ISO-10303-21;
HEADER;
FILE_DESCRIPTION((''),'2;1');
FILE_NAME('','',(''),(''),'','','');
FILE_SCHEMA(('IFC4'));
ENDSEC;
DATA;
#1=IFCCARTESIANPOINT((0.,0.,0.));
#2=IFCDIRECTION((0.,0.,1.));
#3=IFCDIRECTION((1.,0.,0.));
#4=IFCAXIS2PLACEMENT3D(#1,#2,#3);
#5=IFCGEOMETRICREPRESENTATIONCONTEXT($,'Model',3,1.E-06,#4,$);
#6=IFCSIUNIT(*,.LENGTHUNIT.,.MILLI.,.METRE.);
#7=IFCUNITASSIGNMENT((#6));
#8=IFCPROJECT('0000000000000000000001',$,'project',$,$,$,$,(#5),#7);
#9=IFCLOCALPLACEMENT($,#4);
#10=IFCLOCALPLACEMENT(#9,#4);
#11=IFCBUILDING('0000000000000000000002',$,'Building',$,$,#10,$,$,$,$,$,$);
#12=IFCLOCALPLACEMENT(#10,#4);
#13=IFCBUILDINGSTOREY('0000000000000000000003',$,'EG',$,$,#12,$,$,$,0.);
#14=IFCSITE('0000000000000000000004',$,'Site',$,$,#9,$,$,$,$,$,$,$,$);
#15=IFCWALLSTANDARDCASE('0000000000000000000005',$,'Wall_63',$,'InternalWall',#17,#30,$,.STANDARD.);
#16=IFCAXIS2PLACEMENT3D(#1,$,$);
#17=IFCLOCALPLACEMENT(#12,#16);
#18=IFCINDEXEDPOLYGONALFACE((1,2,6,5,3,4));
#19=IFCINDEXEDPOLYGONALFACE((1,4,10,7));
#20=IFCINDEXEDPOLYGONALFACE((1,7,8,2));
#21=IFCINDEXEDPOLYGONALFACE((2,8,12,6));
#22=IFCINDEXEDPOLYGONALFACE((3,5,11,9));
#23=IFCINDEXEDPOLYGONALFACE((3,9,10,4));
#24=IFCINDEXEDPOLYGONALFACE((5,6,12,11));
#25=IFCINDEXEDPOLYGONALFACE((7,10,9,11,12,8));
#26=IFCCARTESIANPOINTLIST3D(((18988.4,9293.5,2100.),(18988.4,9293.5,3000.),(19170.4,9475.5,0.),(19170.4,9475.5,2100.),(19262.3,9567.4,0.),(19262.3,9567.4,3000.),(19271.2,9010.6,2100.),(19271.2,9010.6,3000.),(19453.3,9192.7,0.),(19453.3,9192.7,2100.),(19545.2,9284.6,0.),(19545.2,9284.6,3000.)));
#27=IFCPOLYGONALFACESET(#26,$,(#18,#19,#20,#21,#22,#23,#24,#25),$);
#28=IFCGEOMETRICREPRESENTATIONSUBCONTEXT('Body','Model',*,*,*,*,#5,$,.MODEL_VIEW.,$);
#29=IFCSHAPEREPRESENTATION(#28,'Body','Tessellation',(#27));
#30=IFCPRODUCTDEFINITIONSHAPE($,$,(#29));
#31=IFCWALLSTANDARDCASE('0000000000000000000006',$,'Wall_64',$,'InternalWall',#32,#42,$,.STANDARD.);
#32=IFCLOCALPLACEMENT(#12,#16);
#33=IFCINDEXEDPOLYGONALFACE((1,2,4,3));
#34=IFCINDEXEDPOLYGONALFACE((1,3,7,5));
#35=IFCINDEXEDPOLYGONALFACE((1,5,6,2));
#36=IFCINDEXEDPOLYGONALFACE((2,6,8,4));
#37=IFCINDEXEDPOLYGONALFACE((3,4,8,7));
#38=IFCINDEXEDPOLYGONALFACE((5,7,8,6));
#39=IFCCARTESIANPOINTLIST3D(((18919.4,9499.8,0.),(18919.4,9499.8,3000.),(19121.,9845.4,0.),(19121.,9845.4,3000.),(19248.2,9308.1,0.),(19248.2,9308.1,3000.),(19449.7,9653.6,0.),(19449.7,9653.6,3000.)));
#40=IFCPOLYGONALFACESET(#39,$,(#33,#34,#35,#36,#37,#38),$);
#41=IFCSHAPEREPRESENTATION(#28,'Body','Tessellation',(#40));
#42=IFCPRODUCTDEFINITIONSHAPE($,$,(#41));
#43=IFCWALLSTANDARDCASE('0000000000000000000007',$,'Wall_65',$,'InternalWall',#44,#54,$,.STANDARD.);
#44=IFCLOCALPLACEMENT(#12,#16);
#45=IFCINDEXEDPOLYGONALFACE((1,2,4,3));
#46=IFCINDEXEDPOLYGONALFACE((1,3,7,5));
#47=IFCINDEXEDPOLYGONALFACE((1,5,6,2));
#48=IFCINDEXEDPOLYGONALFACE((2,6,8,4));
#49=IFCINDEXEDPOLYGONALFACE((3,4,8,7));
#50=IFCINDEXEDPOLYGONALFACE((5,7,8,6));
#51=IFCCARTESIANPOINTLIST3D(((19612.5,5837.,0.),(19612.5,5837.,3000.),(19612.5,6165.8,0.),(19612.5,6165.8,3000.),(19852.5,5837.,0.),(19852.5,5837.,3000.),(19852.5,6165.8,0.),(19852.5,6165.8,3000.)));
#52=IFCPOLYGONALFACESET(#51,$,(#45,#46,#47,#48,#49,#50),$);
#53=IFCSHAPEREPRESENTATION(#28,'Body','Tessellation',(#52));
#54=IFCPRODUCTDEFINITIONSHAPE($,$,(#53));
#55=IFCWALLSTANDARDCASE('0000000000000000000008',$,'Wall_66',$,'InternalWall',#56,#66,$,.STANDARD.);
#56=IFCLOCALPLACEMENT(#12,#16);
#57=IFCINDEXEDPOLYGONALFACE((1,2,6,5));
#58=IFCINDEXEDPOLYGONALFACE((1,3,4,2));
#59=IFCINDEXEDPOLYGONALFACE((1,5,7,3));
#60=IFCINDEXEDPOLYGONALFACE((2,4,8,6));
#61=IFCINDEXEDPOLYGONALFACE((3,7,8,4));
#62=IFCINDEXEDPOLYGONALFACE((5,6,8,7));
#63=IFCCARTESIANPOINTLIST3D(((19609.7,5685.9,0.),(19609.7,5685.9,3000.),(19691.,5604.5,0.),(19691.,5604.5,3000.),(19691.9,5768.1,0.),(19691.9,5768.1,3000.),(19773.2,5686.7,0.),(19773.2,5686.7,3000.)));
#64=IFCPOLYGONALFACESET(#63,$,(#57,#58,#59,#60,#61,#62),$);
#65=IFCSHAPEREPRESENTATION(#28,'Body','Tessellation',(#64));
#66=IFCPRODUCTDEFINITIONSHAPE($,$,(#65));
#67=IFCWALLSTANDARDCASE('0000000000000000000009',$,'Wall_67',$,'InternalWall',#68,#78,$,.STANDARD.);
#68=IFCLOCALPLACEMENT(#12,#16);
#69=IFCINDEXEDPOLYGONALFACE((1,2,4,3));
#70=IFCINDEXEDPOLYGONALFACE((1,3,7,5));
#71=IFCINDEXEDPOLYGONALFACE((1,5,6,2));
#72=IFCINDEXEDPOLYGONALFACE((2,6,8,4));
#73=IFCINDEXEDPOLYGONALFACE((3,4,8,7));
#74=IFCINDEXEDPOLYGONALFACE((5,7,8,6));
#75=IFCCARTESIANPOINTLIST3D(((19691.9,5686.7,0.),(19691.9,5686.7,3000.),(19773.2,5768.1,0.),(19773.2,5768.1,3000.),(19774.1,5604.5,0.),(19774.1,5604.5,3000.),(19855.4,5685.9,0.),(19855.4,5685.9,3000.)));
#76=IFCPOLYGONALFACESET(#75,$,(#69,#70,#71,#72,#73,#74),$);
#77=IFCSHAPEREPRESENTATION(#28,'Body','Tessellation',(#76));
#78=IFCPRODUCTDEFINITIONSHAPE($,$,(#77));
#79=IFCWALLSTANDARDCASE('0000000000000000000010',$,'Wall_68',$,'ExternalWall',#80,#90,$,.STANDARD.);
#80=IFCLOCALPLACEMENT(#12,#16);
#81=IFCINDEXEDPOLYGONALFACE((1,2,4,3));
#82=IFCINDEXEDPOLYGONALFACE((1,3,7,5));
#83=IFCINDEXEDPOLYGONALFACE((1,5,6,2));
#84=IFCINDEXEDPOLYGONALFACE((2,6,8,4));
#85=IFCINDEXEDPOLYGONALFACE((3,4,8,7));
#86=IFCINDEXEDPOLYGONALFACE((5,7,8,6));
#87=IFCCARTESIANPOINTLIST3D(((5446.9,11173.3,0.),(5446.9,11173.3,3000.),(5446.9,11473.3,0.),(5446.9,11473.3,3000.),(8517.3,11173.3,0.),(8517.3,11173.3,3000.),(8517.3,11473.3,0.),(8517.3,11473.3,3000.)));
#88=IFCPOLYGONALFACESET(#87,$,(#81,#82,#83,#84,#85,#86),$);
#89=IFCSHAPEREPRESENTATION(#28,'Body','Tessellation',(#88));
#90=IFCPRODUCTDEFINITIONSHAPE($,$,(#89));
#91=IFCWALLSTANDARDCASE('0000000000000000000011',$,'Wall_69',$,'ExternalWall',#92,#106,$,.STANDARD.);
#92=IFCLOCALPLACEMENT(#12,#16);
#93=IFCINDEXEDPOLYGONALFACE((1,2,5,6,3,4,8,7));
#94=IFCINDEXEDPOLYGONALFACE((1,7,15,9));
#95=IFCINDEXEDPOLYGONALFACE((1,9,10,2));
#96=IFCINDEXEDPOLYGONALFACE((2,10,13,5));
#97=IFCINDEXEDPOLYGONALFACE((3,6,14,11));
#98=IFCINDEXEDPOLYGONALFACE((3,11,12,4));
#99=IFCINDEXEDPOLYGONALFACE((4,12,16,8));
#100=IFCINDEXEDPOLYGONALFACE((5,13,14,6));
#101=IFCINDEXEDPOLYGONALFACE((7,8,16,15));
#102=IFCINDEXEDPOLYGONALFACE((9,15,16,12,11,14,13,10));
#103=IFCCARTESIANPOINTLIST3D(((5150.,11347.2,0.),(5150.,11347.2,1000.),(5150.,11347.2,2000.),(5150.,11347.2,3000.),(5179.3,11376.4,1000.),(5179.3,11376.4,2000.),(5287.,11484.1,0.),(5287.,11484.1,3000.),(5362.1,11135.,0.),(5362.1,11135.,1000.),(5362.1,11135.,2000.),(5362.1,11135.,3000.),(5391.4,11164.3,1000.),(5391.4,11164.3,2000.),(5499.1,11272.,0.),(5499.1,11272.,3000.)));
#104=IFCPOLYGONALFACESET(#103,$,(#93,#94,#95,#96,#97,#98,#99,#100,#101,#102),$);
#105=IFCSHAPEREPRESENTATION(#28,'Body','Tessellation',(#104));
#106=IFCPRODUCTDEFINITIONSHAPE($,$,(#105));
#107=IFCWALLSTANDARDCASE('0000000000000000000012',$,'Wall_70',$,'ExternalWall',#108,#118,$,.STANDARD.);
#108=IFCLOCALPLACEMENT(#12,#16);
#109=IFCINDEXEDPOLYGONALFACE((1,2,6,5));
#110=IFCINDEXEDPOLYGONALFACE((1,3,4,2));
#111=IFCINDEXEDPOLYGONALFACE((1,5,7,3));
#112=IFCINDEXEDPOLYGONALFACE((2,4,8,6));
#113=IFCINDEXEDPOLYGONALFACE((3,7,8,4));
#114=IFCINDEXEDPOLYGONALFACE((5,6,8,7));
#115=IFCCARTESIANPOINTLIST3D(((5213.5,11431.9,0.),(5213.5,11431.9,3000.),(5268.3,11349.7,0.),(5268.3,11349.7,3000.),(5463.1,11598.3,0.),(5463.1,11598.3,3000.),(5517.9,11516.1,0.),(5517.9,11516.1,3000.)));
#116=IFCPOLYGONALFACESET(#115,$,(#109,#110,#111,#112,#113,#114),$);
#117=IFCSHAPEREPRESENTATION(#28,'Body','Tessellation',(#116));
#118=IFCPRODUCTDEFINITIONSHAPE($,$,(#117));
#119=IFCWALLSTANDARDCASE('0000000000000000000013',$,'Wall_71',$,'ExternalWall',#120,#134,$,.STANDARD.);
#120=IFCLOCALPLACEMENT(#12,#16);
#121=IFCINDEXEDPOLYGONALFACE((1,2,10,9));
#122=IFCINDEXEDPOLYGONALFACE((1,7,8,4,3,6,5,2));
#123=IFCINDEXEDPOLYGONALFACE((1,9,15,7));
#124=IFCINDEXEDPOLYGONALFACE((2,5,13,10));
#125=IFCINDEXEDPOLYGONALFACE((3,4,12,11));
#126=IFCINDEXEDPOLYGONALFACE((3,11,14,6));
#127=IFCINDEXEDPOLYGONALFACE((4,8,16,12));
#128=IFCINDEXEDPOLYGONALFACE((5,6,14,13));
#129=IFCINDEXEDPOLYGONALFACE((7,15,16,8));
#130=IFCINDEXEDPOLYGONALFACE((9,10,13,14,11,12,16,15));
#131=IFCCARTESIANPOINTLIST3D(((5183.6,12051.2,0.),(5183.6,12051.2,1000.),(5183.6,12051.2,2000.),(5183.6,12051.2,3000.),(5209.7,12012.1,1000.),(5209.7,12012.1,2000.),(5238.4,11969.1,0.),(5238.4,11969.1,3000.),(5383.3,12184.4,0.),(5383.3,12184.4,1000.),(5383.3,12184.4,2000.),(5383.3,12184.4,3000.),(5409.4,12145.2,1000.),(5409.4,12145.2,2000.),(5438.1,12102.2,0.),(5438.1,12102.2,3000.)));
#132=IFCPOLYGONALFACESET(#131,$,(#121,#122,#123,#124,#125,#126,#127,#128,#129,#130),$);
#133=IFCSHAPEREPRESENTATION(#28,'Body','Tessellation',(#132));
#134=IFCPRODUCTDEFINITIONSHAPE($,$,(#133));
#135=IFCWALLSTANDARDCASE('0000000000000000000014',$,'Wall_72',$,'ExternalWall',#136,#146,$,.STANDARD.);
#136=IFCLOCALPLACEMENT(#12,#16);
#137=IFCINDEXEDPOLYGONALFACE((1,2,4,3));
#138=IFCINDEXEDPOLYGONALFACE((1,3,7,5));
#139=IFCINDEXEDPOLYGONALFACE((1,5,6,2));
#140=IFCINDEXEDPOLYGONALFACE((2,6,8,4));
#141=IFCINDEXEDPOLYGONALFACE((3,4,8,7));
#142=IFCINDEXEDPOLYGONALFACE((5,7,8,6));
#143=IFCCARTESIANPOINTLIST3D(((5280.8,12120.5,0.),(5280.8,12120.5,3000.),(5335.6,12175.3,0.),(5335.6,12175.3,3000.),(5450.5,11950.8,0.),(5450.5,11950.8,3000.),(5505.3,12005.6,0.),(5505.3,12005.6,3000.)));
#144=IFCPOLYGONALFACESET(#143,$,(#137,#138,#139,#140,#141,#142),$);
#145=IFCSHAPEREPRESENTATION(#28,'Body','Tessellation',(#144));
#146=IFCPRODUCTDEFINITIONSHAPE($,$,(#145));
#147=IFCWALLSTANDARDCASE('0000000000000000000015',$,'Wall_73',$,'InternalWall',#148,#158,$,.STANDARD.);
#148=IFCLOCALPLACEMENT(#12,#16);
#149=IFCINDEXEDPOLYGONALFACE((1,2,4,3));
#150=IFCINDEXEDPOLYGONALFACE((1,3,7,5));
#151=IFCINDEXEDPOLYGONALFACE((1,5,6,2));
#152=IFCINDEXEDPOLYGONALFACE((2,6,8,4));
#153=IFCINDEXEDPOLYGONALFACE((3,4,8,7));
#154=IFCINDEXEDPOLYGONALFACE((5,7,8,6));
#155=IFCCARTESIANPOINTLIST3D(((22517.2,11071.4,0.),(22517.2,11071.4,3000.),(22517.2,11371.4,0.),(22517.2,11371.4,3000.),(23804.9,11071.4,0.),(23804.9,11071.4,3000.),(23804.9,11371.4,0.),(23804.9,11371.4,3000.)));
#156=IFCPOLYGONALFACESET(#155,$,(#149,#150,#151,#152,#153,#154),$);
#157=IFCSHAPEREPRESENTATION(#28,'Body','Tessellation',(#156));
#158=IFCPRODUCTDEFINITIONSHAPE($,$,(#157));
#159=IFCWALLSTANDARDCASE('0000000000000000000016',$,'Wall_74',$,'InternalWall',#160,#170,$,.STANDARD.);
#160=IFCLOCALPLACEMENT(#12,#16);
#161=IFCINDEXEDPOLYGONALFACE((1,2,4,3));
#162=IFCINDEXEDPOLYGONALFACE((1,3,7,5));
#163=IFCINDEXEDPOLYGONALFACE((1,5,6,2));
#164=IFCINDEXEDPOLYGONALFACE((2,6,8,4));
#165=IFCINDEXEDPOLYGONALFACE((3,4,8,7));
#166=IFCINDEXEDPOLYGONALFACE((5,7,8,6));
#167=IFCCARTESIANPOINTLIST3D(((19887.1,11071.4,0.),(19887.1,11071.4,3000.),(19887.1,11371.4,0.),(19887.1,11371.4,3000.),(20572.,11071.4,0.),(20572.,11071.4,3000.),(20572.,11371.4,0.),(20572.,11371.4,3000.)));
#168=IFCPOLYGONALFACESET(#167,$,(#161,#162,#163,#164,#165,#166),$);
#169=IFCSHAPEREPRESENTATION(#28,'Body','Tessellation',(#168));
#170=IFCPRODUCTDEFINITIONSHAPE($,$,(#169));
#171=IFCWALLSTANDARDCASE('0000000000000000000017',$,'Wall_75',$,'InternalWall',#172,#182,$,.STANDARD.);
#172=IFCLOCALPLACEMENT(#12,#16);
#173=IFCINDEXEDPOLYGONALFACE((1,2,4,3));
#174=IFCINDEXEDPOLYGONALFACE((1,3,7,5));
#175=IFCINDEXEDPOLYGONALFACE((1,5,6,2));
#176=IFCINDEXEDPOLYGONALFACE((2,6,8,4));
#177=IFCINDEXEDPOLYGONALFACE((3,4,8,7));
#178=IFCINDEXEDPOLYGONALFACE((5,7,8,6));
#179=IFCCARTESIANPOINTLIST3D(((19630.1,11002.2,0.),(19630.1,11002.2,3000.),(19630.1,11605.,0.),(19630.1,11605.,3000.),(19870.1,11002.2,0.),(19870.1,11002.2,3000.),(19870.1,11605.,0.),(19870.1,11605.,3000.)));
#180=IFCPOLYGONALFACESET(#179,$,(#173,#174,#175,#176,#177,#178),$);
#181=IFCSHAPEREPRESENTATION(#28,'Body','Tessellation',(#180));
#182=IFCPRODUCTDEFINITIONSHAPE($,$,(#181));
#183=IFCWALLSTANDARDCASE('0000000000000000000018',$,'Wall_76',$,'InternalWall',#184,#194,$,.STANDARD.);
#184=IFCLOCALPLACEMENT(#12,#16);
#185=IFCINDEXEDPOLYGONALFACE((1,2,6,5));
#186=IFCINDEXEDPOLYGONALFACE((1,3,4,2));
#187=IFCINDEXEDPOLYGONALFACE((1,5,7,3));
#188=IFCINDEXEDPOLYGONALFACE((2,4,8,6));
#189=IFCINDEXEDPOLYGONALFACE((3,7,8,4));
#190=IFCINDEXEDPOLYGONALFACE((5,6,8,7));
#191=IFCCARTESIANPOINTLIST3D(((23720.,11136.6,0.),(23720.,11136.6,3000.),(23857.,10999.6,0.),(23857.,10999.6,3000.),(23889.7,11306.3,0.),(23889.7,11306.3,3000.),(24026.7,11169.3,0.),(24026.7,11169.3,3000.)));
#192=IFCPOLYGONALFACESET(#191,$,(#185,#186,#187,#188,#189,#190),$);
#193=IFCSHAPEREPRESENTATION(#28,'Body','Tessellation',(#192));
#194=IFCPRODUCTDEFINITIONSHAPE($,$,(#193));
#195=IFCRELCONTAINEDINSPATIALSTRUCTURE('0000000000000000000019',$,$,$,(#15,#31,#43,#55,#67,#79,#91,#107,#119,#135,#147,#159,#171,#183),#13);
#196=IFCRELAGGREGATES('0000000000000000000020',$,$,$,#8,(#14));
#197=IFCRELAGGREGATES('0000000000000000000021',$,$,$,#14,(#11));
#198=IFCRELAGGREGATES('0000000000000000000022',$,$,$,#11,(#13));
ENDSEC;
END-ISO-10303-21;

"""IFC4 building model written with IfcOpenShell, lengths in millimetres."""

from ifc_helpers import new_model, si_unit, frame, origin_with_axes, place, context, subcontext, project, spatial, rectangle, extrude, element, save


model = new_model("IFC4")

# Units and contexts
model_context = context("Model", 3, precision=1e-06, world=origin_with_axes())
body_context = subcontext(model_context, "Body", "Model", "MODEL_VIEW")
ifc_project = project(units=[si_unit("LENGTHUNIT", "METRE", prefix="MILLI")], contexts=[model_context])

# Site, building, storey
site_placement = place(None, origin_with_axes())
site = spatial("IfcSite", under=ifc_project, at=site_placement, Name="Site")
building_placement = place(site_placement, origin_with_axes())
building = spatial("IfcBuilding", under=site, at=building_placement, Name="Building")
storey_placement = place(building_placement, origin_with_axes())
storey = spatial("IfcBuildingStorey", under=building, at=storey_placement, Name="EG", Elevation=0.0)

# Wall, opening
wall_1_placement = place(storey_placement, origin_with_axes())
wall_1 = element("IfcWallStandardCase", 1, at=wall_1_placement, inside=storey, Name="Wall_63", ObjectType="InternalWall", PredefinedType="STANDARD", context=body_context, shape_type="SweptSolid", body=[
    extrude(rectangle(XDim=387.5, YDim=400.0), frame((19266.8, 9289.0, 0.0), z_axis=(0.0, 0.0, 1.0), x_axis=(-0.707107, -0.707107, 0.0)), (0.0, 0.0, 1.0), 3000.0),
])
opening_1_placement = place(wall_1_placement, origin_with_axes())
element("IfcOpeningElement", 2, at=opening_1_placement, inside=storey, cuts=wall_1, context=body_context, shape_type="SweptSolid", body=[
    extrude(rectangle(XDim=1034.0, YDim=400.0), frame((18946.3, 8968.5, 0.0), z_axis=(0.0, 0.0, 1.0), x_axis=(-0.707107, -0.707107, 0.0)), (0.0, 0.0, 1.0), 2100.0),
])

# Walls
wall_2_placement = place(storey_placement, origin_with_axes())
element("IfcWallStandardCase", 3, at=wall_2_placement, inside=storey, Name="Wall_64", ObjectType="InternalWall", PredefinedType="STANDARD", context=body_context, shape_type="SweptSolid", body=[
    extrude(rectangle(XDim=380.6, YDim=400.0), frame((19184.6, 9576.7, 0.0), z_axis=(0.0, 0.0, 1.0), x_axis=(-0.863779, 0.503871, 0.0)), (0.0, 0.0, 1.0), 3000.0),
])
wall_3_placement = place(storey_placement, origin_with_axes())
element("IfcWallStandardCase", 4, at=wall_3_placement, inside=storey, Name="Wall_65", ObjectType="InternalWall", PredefinedType="STANDARD", context=body_context, shape_type="SweptSolid", body=[
    extrude(rectangle(XDim=328.8, YDim=240.0), frame((19732.5, 6001.4, 0.0), z_axis=(0.0, 0.0, 1.0), x_axis=(0.0, -1.0, 0.0)), (0.0, 0.0, 1.0), 3000.0),
])
wall_4_placement = place(storey_placement, origin_with_axes())
element("IfcWallStandardCase", 5, at=wall_4_placement, inside=storey, Name="Wall_66", ObjectType="InternalWall", PredefinedType="STANDARD", context=body_context, shape_type="SweptSolid", body=[
    extrude(rectangle(XDim=116.2, YDim=115.0), frame((19691.4, 5686.3, 0.0), z_axis=(0.0, 0.0, 1.0), x_axis=(-0.707107, -0.707107, 0.0)), (0.0, 0.0, 1.0), 3000.0),
])
wall_5_placement = place(storey_placement, origin_with_axes())
element("IfcWallStandardCase", 6, at=wall_5_placement, inside=storey, Name="Wall_67", ObjectType="InternalWall", PredefinedType="STANDARD", context=body_context, shape_type="SweptSolid", body=[
    extrude(rectangle(XDim=116.2, YDim=115.0), frame((19773.6, 5686.3, 0.0), z_axis=(0.0, 0.0, 1.0), x_axis=(0.707107, -0.707107, 0.0)), (0.0, 0.0, 1.0), 3000.0),
])
wall_6_placement = place(storey_placement, origin_with_axes())
element("IfcWallStandardCase", 7, at=wall_6_placement, inside=storey, Name="Wall_68", ObjectType="ExternalWall", PredefinedType="STANDARD", context=body_context, shape_type="SweptSolid", body=[
    extrude(rectangle(XDim=3070.4, YDim=300.0), frame((6982.1, 11323.3, 0.0), z_axis=(0.0, 0.0, 1.0), x_axis=(1.0, 0.0, 0.0)), (0.0, 0.0, 1.0), 3000.0),
])

# Wall, opening
wall_7_placement = place(storey_placement, origin_with_axes())
wall_7 = element("IfcWallStandardCase", 8, at=wall_7_placement, inside=storey, Name="Wall_69", ObjectType="ExternalWall", PredefinedType="STANDARD", context=body_context, shape_type="SweptSolid", body=[
    extrude(rectangle(XDim=193.7, YDim=300.0), frame((5324.6, 11309.6, 0.0), z_axis=(0.0, 0.0, 1.0), x_axis=(-0.707107, -0.707107, 0.0)), (0.0, 0.0, 1.0), 3000.0),
])
opening_2_placement = place(wall_7_placement, origin_with_axes())
element("IfcOpeningElement", 9, at=opening_2_placement, inside=storey, cuts=wall_7, context=body_context, shape_type="SweptSolid", body=[
    extrude(rectangle(XDim=627.8, YDim=300.0), frame((5063.4, 11048.4, 1000.0), z_axis=(0.0, 0.0, 1.0), x_axis=(-0.707107, -0.707107, 0.0)), (0.0, 0.0, 1.0), 1000.0),
])

# Wall
wall_8_placement = place(storey_placement, origin_with_axes())
element("IfcWallStandardCase", 10, at=wall_8_placement, inside=storey, Name="Wall_70", ObjectType="ExternalWall", PredefinedType="STANDARD", context=body_context, shape_type="SweptSolid", body=[
    extrude(rectangle(XDim=98.8, YDim=300.0), frame((5365.7, 11474.0, 0.0), z_axis=(0.0, 0.0, 1.0), x_axis=(0.5547, -0.83205, 0.0)), (0.0, 0.0, 1.0), 3000.0),
])

# Wall, opening
wall_9_placement = place(storey_placement, origin_with_axes())
wall_9 = element("IfcWallStandardCase", 11, at=wall_9_placement, inside=storey, Name="Wall_71", ObjectType="ExternalWall", PredefinedType="STANDARD", context=body_context, shape_type="SweptSolid", body=[
    extrude(rectangle(XDim=98.8, YDim=240.0), frame((5310.9, 12076.7, 0.0), z_axis=(0.0, 0.0, 1.0), x_axis=(-0.5547, 0.83205, 0.0)), (0.0, 0.0, 1.0), 3000.0),
])
opening_3_placement = place(wall_9_placement, origin_with_axes())
element("IfcOpeningElement", 12, at=opening_3_placement, inside=storey, cuts=wall_9, context=body_context, shape_type="SweptSolid", body=[
    extrude(rectangle(XDim=2556.6, YDim=240.0), frame((4600.5, 13142.3, 1000.0), z_axis=(0.0, 0.0, 1.0), x_axis=(-0.5547, 0.83205, 0.0)), (0.0, 0.0, 1.0), 1000.0),
])

# Walls
wall_10_placement = place(storey_placement, origin_with_axes())
element("IfcWallStandardCase", 13, at=wall_10_placement, inside=storey, Name="Wall_72", ObjectType="ExternalWall", PredefinedType="STANDARD", context=body_context, shape_type="SweptSolid", body=[
    extrude(rectangle(XDim=77.5, YDim=240.0), frame((5393.1, 12063.0, 0.0), z_axis=(0.0, 0.0, 1.0), x_axis=(0.707107, 0.707107, 0.0)), (0.0, 0.0, 1.0), 3000.0),
])
wall_11_placement = place(storey_placement, origin_with_axes())
element("IfcWallStandardCase", 14, at=wall_11_placement, inside=storey, Name="Wall_73", ObjectType="InternalWall", PredefinedType="STANDARD", context=body_context, shape_type="SweptSolid", body=[
    extrude(rectangle(XDim=1287.7, YDim=300.0), frame((23161.0, 11221.4, 0.0), z_axis=(0.0, 0.0, 1.0), x_axis=(-1.0, 0.0, 0.0)), (0.0, 0.0, 1.0), 3000.0),
])
wall_12_placement = place(storey_placement, origin_with_axes())
element("IfcWallStandardCase", 15, at=wall_12_placement, inside=storey, Name="Wall_74", ObjectType="InternalWall", PredefinedType="STANDARD", context=body_context, shape_type="SweptSolid", body=[
    extrude(rectangle(XDim=684.9, YDim=300.0), frame((20229.5, 11221.4, 0.0), z_axis=(0.0, 0.0, 1.0), x_axis=(-1.0, 0.0, 0.0)), (0.0, 0.0, 1.0), 3000.0),
])
wall_13_placement = place(storey_placement, origin_with_axes())
element("IfcWallStandardCase", 16, at=wall_13_placement, inside=storey, Name="Wall_75", ObjectType="InternalWall", PredefinedType="STANDARD", context=body_context, shape_type="SweptSolid", body=[
    extrude(rectangle(XDim=602.7, YDim=240.0), frame((19750.1, 11303.6, 0.0), z_axis=(0.0, 0.0, 1.0), x_axis=(0.0, -1.0, 0.0)), (0.0, 0.0, 1.0), 3000.0),
])
wall_14_placement = place(storey_placement, origin_with_axes())
element("IfcWallStandardCase", 17, at=wall_14_placement, inside=storey, Name="Wall_76", ObjectType="InternalWall", PredefinedType="STANDARD", context=body_context, shape_type="SweptSolid", body=[
    extrude(rectangle(XDim=193.7, YDim=240.0), frame((23873.4, 11152.9, 0.0), z_axis=(0.0, 0.0, 1.0), x_axis=(0.707107, -0.707107, 0.0)), (0.0, 0.0, 1.0), 3000.0),
])

save(model, "model.ifc")
